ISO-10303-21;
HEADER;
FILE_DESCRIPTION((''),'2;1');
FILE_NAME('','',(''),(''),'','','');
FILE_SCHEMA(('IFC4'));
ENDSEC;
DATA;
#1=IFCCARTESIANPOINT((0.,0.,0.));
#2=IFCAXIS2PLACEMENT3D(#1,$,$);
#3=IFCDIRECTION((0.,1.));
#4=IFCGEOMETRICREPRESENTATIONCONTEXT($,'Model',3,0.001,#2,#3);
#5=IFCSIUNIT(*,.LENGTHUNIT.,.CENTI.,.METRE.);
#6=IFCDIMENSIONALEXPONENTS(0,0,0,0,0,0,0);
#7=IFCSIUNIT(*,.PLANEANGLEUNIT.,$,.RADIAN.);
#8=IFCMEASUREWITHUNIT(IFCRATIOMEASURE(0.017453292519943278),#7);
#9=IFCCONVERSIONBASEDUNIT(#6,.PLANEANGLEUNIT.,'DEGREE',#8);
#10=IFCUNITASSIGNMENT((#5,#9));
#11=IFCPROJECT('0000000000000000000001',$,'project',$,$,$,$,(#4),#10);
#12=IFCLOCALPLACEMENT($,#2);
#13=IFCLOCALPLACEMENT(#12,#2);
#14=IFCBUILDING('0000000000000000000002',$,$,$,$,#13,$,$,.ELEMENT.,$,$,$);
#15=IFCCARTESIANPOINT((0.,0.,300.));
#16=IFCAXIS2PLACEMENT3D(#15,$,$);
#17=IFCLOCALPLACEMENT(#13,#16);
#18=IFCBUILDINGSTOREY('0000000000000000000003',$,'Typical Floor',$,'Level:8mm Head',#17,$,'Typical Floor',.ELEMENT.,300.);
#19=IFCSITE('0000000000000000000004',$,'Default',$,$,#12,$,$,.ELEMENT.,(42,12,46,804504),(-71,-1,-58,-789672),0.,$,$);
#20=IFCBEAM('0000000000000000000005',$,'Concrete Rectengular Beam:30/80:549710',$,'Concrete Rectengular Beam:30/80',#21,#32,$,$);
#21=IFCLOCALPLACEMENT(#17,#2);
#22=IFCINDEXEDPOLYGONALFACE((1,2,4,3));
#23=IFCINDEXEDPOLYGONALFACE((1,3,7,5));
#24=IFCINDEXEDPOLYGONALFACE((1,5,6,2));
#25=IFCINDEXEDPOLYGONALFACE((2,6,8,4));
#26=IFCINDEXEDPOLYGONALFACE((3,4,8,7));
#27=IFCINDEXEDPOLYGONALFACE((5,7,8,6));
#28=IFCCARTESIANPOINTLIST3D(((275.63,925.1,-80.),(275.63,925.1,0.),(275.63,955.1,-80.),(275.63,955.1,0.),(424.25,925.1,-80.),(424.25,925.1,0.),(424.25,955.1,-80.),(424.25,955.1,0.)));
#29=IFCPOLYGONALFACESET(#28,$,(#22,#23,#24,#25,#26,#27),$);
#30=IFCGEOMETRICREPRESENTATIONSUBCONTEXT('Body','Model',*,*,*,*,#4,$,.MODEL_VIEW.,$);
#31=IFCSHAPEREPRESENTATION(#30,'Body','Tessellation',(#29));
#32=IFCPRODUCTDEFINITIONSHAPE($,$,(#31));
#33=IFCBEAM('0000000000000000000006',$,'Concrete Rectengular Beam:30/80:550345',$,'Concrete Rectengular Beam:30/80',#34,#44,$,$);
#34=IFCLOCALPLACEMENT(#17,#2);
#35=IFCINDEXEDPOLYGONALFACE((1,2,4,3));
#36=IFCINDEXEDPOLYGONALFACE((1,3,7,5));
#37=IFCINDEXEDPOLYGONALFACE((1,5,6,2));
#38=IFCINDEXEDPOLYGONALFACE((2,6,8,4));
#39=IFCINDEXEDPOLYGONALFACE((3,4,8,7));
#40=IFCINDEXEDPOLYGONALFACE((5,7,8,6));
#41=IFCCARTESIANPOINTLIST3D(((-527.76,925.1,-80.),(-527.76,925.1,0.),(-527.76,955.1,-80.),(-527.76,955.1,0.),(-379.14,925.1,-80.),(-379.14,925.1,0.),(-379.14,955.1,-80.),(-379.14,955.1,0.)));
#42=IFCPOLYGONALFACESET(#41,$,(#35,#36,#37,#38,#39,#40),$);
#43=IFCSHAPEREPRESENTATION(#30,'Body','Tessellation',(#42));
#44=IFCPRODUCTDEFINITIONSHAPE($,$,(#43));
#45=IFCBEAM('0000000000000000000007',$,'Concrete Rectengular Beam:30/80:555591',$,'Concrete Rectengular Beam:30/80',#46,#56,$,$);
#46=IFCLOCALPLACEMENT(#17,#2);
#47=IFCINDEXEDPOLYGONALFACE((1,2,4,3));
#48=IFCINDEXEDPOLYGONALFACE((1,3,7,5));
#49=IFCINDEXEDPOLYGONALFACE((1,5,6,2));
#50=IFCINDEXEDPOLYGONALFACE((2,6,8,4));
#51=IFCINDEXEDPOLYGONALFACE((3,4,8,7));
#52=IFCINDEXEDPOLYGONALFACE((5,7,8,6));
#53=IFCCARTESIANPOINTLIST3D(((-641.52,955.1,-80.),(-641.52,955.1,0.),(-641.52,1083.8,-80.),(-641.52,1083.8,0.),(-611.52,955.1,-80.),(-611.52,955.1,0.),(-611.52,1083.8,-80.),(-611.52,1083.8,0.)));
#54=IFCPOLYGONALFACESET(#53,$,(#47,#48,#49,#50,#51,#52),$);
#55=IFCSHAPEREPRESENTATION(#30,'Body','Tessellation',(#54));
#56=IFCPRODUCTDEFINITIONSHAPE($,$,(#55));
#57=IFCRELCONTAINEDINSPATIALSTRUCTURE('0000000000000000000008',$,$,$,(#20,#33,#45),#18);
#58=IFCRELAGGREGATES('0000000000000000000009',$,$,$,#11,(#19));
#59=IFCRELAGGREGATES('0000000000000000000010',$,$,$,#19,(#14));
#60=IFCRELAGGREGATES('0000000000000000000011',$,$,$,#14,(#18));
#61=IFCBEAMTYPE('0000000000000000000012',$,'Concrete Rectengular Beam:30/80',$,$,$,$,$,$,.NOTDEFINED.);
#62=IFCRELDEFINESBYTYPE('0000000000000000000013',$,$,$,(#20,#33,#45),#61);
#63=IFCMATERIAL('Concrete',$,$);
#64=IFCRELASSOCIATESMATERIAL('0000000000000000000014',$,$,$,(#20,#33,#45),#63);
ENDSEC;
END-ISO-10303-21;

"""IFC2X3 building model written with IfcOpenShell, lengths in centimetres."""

from ifc_helpers import new_model, entity, si_unit, converted_unit, direction, frame, frame_2d, origin, place, context, subcontext, project, spatial, rectangle, extrude, material, type_object, element, save


model = new_model("IFC2X3")

# Units and contexts
model_context = context("Model", 3, precision=0.001, world=origin(), true_north=direction((0.0, 1.0)))
body_context = subcontext(model_context, "Body", "Model", "MODEL_VIEW")
ifc_project = project(units=[si_unit("LENGTHUNIT", "METRE", prefix="CENTI"), converted_unit("PLANEANGLEUNIT", "DEGREE", entity("IfcRatioMeasure", 0.017453292519943278), si_unit("PLANEANGLEUNIT", "RADIAN"), dimensions=[0, 0, 0, 0, 0, 0, 0])], contexts=[model_context])

# Site, building, storey
site_placement = place(None, origin())
site = spatial("IfcSite", under=ifc_project, at=site_placement, Name="Default", CompositionType="ELEMENT", RefLatitude=(42, 12, 46, 804504), RefLongitude=(-71, -1, -58, -789672), RefElevation=0.0)
building_placement = place(site_placement, origin())
building = spatial("IfcBuilding", under=site, at=building_placement, CompositionType="ELEMENT")
storey_placement = place(building_placement, frame((0.0, 0.0, 300.0)))
storey = spatial("IfcBuildingStorey", under=building, at=storey_placement, Name="Typical Floor", ObjectType="Level:8mm Head", LongName="Typical Floor", CompositionType="ELEMENT", Elevation=300.0)

# Beams
ifc_material = material(Name="Concrete")
beam_type = type_object("IfcBeamType", Name="Concrete Rectengular Beam:30/80", PredefinedType="NOTDEFINED")
beam_1_placement = place(storey_placement, frame((424.25, 940.1, 0.0), z_axis=(0.0, 0.0, 1.0), x_axis=(-1.0, 0.0, 0.0)))
element("IfcBeam", 1, at=beam_1_placement, inside=storey, type_object=beam_type, material=ifc_material, Name="Concrete Rectengular Beam:30/80:549710", ObjectType="Concrete Rectengular Beam:30/80", context=body_context, shape_type="SweptSolid", body=[
    extrude(rectangle(XDim=80.0, YDim=30.0, at=frame_2d((0.0, 0.0), x_axis=(1.0, 0.0))), frame((0.0, 0.0, -40.0), z_axis=(1.0, 0.0, 0.0), x_axis=(0.0, 0.0, -1.0)), (0.0, 0.0, 1.0), 148.62),
])
beam_2_placement = place(storey_placement, frame((-527.76, 940.1, 0.0)))
element("IfcBeam", 2, at=beam_2_placement, inside=storey, type_object=beam_type, material=ifc_material, Name="Concrete Rectengular Beam:30/80:550345", ObjectType="Concrete Rectengular Beam:30/80", context=body_context, shape_type="SweptSolid", body=[
    extrude(rectangle(XDim=80.0, YDim=30.0, at=frame_2d((0.0, 0.0), x_axis=(1.0, 0.0))), frame((0.0, 0.0, -40.0), z_axis=(1.0, 0.0, 0.0), x_axis=(0.0, 0.0, -1.0)), (0.0, 0.0, 1.0), 148.62),
])
beam_3_placement = place(storey_placement, frame((-626.52, 940.1, 0.0), z_axis=(0.0, 0.0, 1.0), x_axis=(0.0, 1.0, 0.0)))
element("IfcBeam", 3, at=beam_3_placement, inside=storey, type_object=beam_type, material=ifc_material, Name="Concrete Rectengular Beam:30/80:555591", ObjectType="Concrete Rectengular Beam:30/80", context=body_context, shape_type="SweptSolid", body=[
    extrude(rectangle(XDim=80.0, YDim=30.0, at=frame_2d((0.0, 0.0), x_axis=(1.0, 0.0))), frame((15.0, 0.0, -40.0), z_axis=(1.0, 0.0, 0.0), x_axis=(0.0, 0.0, -1.0)), (0.0, 0.0, 1.0), 128.69),
])

save(model, "model.ifc")
